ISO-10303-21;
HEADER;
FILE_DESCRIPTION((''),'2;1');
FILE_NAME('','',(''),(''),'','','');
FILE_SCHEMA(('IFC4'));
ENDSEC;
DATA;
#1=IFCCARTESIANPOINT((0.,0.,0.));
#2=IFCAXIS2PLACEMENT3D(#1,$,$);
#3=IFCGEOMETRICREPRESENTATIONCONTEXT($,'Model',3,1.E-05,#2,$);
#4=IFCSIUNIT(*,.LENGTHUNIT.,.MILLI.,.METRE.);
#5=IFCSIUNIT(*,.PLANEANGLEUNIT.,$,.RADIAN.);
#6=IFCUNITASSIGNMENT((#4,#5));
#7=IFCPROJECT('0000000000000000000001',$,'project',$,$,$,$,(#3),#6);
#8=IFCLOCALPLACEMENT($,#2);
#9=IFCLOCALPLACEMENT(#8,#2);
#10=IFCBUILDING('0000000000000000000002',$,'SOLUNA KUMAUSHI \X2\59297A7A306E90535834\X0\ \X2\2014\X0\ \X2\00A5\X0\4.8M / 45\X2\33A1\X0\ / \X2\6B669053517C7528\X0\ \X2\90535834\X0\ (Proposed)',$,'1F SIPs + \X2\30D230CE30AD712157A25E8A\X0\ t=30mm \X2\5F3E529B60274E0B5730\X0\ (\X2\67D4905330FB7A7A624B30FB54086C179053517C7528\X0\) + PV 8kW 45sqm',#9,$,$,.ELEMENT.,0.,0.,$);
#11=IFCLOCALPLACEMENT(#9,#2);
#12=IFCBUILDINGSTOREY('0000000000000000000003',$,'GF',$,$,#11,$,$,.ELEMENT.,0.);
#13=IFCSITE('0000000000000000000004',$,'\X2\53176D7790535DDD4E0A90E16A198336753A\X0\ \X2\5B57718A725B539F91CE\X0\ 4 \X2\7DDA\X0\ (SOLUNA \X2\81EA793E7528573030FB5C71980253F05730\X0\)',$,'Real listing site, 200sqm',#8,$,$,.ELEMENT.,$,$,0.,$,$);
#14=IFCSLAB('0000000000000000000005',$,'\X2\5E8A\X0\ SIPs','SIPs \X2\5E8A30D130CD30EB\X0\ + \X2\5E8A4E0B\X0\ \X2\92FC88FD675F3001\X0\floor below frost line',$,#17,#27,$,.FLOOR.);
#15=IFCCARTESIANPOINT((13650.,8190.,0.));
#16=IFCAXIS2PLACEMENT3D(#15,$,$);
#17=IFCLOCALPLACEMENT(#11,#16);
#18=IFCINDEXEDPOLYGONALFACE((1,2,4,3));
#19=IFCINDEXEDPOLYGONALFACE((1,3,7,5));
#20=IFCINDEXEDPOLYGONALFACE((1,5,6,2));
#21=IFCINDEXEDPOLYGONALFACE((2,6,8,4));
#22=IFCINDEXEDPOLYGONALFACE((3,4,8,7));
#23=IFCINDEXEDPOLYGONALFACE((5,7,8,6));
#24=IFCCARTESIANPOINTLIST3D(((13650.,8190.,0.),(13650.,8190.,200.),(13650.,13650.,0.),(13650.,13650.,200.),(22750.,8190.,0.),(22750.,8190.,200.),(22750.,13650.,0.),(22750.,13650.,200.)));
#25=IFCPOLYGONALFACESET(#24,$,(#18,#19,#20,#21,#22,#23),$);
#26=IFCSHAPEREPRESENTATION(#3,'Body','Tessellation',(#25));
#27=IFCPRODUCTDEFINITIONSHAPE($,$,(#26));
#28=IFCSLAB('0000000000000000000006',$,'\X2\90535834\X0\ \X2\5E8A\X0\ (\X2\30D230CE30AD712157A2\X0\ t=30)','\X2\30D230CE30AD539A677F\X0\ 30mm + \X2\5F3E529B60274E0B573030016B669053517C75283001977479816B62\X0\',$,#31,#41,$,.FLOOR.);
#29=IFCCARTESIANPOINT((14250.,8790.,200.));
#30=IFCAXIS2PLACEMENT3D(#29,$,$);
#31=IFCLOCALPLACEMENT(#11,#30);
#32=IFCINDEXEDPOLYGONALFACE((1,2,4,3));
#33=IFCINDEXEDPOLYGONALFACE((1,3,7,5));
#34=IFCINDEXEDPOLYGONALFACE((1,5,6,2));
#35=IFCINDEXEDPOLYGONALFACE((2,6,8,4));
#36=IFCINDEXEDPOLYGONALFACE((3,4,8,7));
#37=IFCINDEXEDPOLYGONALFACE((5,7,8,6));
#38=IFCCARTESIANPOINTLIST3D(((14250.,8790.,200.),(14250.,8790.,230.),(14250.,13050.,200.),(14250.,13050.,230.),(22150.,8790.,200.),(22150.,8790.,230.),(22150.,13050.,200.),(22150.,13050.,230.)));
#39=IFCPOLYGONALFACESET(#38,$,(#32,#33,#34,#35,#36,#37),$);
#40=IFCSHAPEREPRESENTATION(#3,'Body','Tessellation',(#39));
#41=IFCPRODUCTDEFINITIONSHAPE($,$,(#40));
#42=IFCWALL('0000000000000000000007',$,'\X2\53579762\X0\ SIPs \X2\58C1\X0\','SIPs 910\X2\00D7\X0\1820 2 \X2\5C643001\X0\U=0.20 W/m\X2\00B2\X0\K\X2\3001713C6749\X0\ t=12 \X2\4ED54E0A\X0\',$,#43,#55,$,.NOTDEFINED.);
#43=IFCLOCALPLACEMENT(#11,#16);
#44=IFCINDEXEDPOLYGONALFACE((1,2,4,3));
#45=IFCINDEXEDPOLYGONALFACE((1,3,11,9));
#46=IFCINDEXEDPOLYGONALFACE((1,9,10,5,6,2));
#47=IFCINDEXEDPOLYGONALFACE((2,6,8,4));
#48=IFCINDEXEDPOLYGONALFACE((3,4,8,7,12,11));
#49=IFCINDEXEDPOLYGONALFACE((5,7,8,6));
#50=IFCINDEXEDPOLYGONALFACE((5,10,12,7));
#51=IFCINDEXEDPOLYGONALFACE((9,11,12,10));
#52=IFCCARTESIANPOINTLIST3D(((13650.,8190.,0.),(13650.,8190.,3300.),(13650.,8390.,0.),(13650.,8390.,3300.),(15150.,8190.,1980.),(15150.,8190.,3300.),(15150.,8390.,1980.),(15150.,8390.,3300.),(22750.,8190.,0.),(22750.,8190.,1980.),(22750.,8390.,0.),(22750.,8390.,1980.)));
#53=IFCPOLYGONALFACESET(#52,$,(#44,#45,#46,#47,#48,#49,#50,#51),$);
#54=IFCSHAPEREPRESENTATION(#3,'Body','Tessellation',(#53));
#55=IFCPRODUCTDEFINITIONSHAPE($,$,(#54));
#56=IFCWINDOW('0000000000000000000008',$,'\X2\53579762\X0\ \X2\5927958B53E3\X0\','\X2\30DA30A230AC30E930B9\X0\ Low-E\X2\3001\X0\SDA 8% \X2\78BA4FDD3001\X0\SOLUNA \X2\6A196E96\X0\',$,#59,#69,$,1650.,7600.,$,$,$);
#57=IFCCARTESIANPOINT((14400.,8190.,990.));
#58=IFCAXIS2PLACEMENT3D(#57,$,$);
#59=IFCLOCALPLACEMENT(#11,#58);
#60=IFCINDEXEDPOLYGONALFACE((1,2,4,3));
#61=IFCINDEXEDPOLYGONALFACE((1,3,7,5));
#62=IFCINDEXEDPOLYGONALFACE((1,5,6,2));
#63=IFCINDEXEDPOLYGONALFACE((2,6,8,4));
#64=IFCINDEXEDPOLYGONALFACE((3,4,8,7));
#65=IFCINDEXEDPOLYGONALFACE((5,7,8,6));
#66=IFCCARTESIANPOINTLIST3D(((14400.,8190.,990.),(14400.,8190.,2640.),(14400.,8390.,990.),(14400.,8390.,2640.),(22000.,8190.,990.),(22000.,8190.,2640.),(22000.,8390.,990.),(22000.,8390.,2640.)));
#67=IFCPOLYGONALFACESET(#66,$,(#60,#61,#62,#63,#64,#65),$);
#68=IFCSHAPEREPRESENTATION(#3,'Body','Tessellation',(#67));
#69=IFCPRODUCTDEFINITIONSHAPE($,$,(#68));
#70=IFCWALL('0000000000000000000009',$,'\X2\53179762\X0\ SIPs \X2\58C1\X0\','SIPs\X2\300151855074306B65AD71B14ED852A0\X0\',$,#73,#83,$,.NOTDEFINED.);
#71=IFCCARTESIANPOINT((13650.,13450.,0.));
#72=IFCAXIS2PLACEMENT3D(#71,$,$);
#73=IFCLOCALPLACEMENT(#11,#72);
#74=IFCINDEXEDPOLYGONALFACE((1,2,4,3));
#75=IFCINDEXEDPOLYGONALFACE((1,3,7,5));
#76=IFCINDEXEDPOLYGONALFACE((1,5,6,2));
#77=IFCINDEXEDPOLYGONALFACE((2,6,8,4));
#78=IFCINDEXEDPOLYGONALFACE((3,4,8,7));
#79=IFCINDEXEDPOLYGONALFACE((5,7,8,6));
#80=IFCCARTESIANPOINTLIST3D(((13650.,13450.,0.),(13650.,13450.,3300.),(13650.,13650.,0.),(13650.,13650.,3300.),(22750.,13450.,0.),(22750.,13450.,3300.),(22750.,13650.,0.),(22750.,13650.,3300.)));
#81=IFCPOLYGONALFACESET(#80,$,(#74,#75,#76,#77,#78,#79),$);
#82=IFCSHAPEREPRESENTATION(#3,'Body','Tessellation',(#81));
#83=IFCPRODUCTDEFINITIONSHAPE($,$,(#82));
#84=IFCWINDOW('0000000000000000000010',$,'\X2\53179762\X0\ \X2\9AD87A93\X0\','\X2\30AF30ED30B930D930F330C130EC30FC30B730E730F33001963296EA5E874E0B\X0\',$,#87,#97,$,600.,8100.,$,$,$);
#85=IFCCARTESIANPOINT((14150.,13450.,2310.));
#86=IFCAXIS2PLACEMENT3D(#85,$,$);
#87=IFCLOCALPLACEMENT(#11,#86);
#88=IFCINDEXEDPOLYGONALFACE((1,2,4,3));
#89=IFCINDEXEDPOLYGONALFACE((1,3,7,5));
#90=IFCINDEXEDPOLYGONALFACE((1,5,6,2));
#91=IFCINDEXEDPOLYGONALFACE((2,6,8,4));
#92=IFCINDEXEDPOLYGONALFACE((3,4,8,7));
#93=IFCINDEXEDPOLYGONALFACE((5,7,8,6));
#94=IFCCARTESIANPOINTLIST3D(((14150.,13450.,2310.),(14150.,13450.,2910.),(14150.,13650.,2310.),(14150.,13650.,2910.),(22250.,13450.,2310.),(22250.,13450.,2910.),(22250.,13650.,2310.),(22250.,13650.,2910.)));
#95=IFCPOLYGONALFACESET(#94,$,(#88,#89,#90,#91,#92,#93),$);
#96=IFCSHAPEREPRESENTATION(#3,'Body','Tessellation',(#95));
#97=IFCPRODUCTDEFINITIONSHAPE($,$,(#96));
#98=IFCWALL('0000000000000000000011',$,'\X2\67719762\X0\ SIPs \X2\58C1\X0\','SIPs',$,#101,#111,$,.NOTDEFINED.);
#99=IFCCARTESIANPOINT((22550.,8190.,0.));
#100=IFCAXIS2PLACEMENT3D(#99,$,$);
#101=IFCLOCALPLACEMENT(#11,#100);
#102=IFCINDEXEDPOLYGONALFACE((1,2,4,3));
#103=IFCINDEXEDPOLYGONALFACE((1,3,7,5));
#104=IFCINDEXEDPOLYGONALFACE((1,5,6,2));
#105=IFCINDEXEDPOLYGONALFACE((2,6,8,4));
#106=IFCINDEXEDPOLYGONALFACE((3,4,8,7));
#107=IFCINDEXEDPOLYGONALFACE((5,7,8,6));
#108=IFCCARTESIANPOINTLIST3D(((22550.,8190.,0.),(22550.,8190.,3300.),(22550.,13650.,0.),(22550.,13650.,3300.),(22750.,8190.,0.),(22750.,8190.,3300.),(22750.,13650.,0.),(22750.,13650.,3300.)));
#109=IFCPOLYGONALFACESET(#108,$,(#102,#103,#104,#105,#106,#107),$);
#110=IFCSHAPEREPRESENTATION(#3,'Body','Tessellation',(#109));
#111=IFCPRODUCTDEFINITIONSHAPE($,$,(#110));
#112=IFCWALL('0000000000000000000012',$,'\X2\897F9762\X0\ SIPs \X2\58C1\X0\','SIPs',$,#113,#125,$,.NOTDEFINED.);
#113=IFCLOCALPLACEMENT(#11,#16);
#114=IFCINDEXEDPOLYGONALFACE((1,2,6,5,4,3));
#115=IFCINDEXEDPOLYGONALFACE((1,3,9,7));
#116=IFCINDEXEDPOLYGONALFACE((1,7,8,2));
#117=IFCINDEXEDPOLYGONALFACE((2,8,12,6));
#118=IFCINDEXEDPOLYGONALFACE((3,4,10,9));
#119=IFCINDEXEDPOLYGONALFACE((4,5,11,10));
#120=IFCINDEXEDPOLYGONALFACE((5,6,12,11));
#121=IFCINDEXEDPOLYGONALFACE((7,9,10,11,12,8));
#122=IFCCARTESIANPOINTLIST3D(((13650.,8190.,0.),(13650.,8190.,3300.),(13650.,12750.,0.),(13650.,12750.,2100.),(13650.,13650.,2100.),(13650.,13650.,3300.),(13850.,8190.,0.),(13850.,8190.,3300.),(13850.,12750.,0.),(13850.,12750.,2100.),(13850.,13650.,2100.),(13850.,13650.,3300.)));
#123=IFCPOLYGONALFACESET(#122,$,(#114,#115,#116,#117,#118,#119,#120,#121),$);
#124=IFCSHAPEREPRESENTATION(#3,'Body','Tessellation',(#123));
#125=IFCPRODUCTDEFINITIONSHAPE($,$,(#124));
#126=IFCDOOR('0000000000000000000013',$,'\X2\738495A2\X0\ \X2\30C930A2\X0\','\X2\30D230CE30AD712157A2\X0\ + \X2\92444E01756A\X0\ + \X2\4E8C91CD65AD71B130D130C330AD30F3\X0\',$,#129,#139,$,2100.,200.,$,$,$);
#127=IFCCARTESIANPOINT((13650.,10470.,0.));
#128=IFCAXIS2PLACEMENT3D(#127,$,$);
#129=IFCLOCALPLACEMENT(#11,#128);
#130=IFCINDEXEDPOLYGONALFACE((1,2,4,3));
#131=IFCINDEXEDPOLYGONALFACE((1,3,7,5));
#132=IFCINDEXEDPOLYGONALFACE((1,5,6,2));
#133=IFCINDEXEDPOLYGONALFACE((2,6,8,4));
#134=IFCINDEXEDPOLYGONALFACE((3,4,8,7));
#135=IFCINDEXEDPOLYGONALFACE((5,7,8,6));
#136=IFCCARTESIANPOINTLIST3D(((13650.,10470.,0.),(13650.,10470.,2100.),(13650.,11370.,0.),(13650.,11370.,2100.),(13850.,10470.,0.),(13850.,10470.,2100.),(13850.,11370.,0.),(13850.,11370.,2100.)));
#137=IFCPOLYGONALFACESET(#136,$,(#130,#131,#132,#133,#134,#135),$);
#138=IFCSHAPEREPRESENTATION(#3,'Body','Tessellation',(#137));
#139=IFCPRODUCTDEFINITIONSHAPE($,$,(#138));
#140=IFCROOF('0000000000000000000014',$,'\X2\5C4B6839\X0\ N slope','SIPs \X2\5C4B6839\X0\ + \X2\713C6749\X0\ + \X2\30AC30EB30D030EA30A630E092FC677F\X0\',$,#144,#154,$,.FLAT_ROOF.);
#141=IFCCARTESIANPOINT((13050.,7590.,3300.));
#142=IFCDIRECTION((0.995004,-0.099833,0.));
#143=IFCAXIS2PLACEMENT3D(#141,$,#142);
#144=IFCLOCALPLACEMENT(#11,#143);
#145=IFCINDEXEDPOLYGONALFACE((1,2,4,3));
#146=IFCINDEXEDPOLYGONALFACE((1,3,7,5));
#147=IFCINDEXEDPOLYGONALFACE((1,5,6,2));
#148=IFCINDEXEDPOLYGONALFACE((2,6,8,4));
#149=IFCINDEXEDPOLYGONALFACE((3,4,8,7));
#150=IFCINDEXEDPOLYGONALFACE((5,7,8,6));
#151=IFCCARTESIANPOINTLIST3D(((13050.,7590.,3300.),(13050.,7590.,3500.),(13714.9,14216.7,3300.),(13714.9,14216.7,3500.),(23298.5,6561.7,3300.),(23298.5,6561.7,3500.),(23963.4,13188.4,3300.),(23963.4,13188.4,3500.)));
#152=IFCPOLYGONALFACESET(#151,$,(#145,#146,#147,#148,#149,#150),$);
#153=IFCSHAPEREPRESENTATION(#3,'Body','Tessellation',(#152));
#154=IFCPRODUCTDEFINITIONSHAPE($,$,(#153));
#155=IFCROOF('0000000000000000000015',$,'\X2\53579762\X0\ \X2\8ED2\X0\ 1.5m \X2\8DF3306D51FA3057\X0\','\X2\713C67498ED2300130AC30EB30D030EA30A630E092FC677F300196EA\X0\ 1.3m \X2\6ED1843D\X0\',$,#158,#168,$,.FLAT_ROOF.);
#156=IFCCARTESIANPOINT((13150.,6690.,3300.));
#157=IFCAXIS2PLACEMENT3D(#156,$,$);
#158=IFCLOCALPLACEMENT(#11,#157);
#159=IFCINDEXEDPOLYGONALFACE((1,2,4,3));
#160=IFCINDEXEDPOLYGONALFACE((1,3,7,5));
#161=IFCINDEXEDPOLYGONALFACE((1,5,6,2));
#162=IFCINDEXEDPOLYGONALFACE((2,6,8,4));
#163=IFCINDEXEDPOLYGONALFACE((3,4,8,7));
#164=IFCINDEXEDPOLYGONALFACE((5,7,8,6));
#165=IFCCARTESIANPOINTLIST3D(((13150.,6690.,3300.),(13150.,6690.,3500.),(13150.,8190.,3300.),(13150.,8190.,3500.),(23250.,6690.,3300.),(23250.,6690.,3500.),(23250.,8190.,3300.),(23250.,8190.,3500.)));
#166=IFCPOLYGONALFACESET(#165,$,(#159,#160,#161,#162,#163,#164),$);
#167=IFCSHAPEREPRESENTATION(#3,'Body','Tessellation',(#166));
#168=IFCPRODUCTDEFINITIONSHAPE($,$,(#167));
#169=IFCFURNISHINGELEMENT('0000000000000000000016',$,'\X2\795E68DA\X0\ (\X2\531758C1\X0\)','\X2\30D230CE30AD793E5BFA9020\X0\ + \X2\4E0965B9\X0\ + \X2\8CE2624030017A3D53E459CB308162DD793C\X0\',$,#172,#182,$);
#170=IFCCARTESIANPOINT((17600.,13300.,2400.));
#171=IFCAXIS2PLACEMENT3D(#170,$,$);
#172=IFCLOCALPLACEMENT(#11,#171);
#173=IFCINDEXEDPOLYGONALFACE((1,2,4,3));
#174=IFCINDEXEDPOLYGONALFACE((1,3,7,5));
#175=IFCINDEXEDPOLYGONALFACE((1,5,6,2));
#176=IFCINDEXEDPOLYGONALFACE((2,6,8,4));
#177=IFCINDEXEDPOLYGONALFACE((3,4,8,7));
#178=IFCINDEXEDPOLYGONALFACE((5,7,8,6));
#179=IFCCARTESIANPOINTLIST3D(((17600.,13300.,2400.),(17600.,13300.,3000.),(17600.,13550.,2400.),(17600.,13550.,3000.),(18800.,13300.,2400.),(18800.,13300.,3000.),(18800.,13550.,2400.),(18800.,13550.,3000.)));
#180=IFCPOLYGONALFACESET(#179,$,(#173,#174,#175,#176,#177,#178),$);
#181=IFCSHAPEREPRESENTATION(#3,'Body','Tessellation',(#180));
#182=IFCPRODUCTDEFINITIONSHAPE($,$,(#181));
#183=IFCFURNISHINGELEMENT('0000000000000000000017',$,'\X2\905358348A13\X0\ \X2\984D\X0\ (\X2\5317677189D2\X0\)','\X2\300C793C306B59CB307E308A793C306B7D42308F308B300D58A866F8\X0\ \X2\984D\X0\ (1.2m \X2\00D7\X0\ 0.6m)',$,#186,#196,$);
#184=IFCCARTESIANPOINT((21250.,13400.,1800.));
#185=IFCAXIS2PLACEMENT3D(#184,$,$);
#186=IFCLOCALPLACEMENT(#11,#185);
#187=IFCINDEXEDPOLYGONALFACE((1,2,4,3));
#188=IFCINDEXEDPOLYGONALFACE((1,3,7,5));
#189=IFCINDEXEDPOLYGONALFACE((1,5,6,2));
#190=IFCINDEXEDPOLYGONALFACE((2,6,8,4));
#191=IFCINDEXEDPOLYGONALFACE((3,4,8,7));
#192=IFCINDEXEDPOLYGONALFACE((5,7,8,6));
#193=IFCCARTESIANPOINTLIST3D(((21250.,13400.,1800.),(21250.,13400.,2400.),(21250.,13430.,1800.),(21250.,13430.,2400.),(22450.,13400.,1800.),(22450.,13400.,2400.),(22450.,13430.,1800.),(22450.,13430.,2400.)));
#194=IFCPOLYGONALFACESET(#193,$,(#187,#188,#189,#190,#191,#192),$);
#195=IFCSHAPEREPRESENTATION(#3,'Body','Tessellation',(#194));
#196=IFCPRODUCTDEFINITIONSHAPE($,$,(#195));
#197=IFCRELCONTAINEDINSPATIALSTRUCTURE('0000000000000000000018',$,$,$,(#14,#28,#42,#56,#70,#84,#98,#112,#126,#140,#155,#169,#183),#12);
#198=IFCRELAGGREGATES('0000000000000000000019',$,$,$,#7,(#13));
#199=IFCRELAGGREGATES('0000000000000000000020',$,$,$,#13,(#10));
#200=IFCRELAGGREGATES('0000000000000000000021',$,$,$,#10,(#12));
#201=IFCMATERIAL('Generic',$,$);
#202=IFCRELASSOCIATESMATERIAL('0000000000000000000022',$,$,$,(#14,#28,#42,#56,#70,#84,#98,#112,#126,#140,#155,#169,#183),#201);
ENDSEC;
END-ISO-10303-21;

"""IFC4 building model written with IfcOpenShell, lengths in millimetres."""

from ifc_helpers import new_model, si_unit, frame, frame_2d, origin, place, context, project, spatial, rectangle, extrude, material, element, fill, save


model = new_model("IFC4")

# Units and contexts
model_context = context("Model", 3, precision=1e-05, world=origin())
ifc_project = project(units=[si_unit("LENGTHUNIT", "METRE", prefix="MILLI"), si_unit("PLANEANGLEUNIT", "RADIAN")], contexts=[model_context])

# Site, building, storey
site_placement = place(None, origin())
site = spatial("IfcSite", under=ifc_project, at=site_placement, Name="北海道川上郡標茶町 字熊牛原野 4 線 (SOLUNA 自社用地・山頂台地)", ObjectType="Real listing site, 200sqm", CompositionType="ELEMENT", RefElevation=0.0)
building_placement = place(site_placement, origin())
building = spatial("IfcBuilding", under=site, at=building_placement, Name="SOLUNA KUMAUSHI 天空の道場 — ¥4.8M / 45㎡ / 武道兼用 道場 (Proposed)", ObjectType="1F SIPs + ヒノキ無垢床 t=30mm 弾力性下地 (柔道・空手・合気道兼用) + PV 8kW 45sqm", CompositionType="ELEMENT", ElevationOfRefHeight=0.0, ElevationOfTerrain=0.0)
storey_placement = place(building_placement, origin())
storey = spatial("IfcBuildingStorey", under=building, at=storey_placement, Name="GF", CompositionType="ELEMENT", Elevation=0.0)

# Slabs
ifc_material = material(Name="Generic")
slab_1_placement = place(storey_placement, frame((13650.0, 8190.0, 0.0)))
element("IfcSlab", 1, at=slab_1_placement, inside=storey, material=ifc_material, Name="床 SIPs", Description="SIPs 床パネル + 床下 鋼製束、floor below frost line", PredefinedType="FLOOR", context=model_context, shape_type="SweptSolid", body=[
    extrude(rectangle(XDim=9100.0, YDim=5460.0, at=frame_2d((4550.0, 2730.0))), frame((13650.0, 8190.0, 0.0)), (0.0, 0.0, 1.0), 200.0),
])
slab_2_placement = place(storey_placement, frame((14250.0, 8790.0, 200.0)))
element("IfcSlab", 2, at=slab_2_placement, inside=storey, material=ifc_material, Name="道場 床 (ヒノキ無垢 t=30)", Description="ヒノキ厚板 30mm + 弾力性下地、武道兼用、靴禁止", PredefinedType="FLOOR", context=model_context, shape_type="SweptSolid", body=[
    extrude(rectangle(XDim=7900.0, YDim=4260.0, at=frame_2d((3950.0, 2130.0))), frame((14250.0, 8790.0, 200.0)), (0.0, 0.0, 1.0), 30.0),
])

# Walls, openings, windows
wall_1_placement = place(storey_placement, frame((13650.0, 8190.0, 0.0)))
wall_1 = element("IfcWall", 3, at=wall_1_placement, inside=storey, material=ifc_material, Name="南面 SIPs 壁", Description="SIPs 910×1820 2 層、U=0.20 W/m²K、焼杉 t=12 仕上", PredefinedType="NOTDEFINED", context=model_context, shape_type="SweptSolid", body=[
    extrude(rectangle(XDim=9100.0, YDim=200.0, at=frame_2d((4550.0, 100.0))), frame((13650.0, 8190.0, 0.0)), (0.0, 0.0, 1.0), 3300.0),
])
opening_1_placement = place(storey_placement, frame((14400.0, 8190.0, 990.0)))
opening_1 = element("IfcOpeningElement", 4, at=opening_1_placement, cuts=wall_1, PredefinedType="NOTDEFINED", context=model_context, shape_type="SweptSolid", body=[
    extrude(rectangle(XDim=7600.0, YDim=200.0, at=frame_2d((3800.0, 100.0))), frame((14400.0, 8190.0, 990.0)), (0.0, 0.0, 1.0), 1650.0),
])
window_1_placement = place(storey_placement, frame((14400.0, 8190.0, 990.0)))
window_1 = element("IfcWindow", 5, at=window_1_placement, inside=storey, material=ifc_material, Name="南面 大開口", Description="ペアガラス Low-E、SDA 8% 確保、SOLUNA 標準", OverallHeight=1650.0, OverallWidth=7600.0, context=model_context, shape_type="SweptSolid", body=[
    extrude(rectangle(XDim=7600.0, YDim=200.0, at=frame_2d((3800.0, 100.0))), frame((14400.0, 8190.0, 990.0)), (0.0, 0.0, 1.0), 1650.0),
])
fill(opening_1, window_1)
wall_2_placement = place(storey_placement, frame((13650.0, 13450.0, 0.0)))
wall_2 = element("IfcWall", 6, at=wall_2_placement, inside=storey, material=ifc_material, Name="北面 SIPs 壁", Description="SIPs、内側に断熱付加", PredefinedType="NOTDEFINED", context=model_context, shape_type="SweptSolid", body=[
    extrude(rectangle(XDim=9100.0, YDim=200.0, at=frame_2d((4550.0, 100.0))), frame((13650.0, 13450.0, 0.0)), (0.0, 0.0, 1.0), 3300.0),
])
opening_2_placement = place(storey_placement, frame((14150.0, 13450.0, 2310.0)))
opening_2 = element("IfcOpeningElement", 7, at=opening_2_placement, cuts=wall_2, PredefinedType="NOTDEFINED", context=model_context, shape_type="SweptSolid", body=[
    extrude(rectangle(XDim=8100.0, YDim=200.0, at=frame_2d((4050.0, 100.0))), frame((14150.0, 13450.0, 2310.0)), (0.0, 0.0, 1.0), 600.0),
])
window_2_placement = place(storey_placement, frame((14150.0, 13450.0, 2310.0)))
window_2 = element("IfcWindow", 8, at=window_2_placement, inside=storey, material=ifc_material, Name="北面 高窓", Description="クロスベンチレーション、防雪庇下", OverallHeight=600.0, OverallWidth=8100.0, context=model_context, shape_type="SweptSolid", body=[
    extrude(rectangle(XDim=8100.0, YDim=200.0, at=frame_2d((4050.0, 100.0))), frame((14150.0, 13450.0, 2310.0)), (0.0, 0.0, 1.0), 600.0),
])
fill(opening_2, window_2)

# Wall
wall_3_placement = place(storey_placement, frame((22550.0, 8190.0, 0.0)))
element("IfcWall", 9, at=wall_3_placement, inside=storey, material=ifc_material, Name="東面 SIPs 壁", Description="SIPs", PredefinedType="NOTDEFINED", context=model_context, shape_type="SweptSolid", body=[
    extrude(rectangle(XDim=200.0, YDim=5460.0, at=frame_2d((100.0, 2730.0))), frame((22550.0, 8190.0, 0.0)), (0.0, 0.0, 1.0), 3300.0),
])

# Wall, opening, door
wall_4_placement = place(storey_placement, frame((13650.0, 8190.0, 0.0)))
wall_4 = element("IfcWall", 10, at=wall_4_placement, inside=storey, material=ifc_material, Name="西面 SIPs 壁", Description="SIPs", PredefinedType="NOTDEFINED", context=model_context, shape_type="SweptSolid", body=[
    extrude(rectangle(XDim=200.0, YDim=5460.0, at=frame_2d((100.0, 2730.0))), frame((13650.0, 8190.0, 0.0)), (0.0, 0.0, 1.0), 3300.0),
])
opening_3_placement = place(storey_placement, frame((13650.0, 10470.0, 0.0)))
opening_3 = element("IfcOpeningElement", 11, at=opening_3_placement, cuts=wall_4, PredefinedType="NOTDEFINED", context=model_context, shape_type="SweptSolid", body=[
    extrude(rectangle(XDim=200.0, YDim=900.0, at=frame_2d((100.0, 450.0))), frame((13650.0, 10470.0, 0.0)), (0.0, 0.0, 1.0), 2100.0),
])
door_placement = place(storey_placement, frame((13650.0, 10470.0, 0.0)))
door = element("IfcDoor", 12, at=door_placement, inside=storey, material=ifc_material, Name="玄関 ドア", Description="ヒノキ無垢 + 鉄丁番 + 二重断熱パッキン", OverallHeight=2100.0, OverallWidth=200.0, context=model_context, shape_type="SweptSolid", body=[
    extrude(rectangle(XDim=200.0, YDim=900.0, at=frame_2d((100.0, 450.0))), frame((13650.0, 10470.0, 0.0)), (0.0, 0.0, 1.0), 2100.0),
])
fill(opening_3, door)

# Roofs
roof_1_placement = place(storey_placement, frame((13050.0, 7590.0, 3300.0), x_axis=(0.995004, -0.099833, 0.0)))
element("IfcRoof", 13, at=roof_1_placement, inside=storey, material=ifc_material, Name="屋根 N slope", Description="SIPs 屋根 + 焼杉 + ガルバリウム鋼板", PredefinedType="FLAT_ROOF", context=model_context, shape_type="SweptSolid", body=[
    extrude(rectangle(XDim=10300.0, YDim=6660.0, at=frame_2d((5150.0, 3330.0))), frame((13050.0, 7590.0, 3300.0), x_axis=(0.995004, -0.099833, 0.0)), (0.0, 0.0, 1.0), 200.0),
])
roof_2_placement = place(storey_placement, frame((13150.0, 6690.0, 3300.0)))
element("IfcRoof", 14, at=roof_2_placement, inside=storey, material=ifc_material, Name="南面 軒 1.5m 跳ね出し", Description="焼杉軒、ガルバリウム鋼板、雪 1.3m 滑落", PredefinedType="FLAT_ROOF", context=model_context, shape_type="SweptSolid", body=[
    extrude(rectangle(XDim=10100.0, YDim=1500.0, at=frame_2d((5050.0, 750.0))), frame((13150.0, 6690.0, 3300.0)), (0.0, 0.0, 1.0), 200.0),
])

# Furnishing elements
furnishing_1_placement = place(storey_placement, frame((17600.0, 13300.0, 2400.0)))
element("IfcFurnishingElement", 15, at=furnishing_1_placement, inside=storey, material=ifc_material, Name="神棚 (北壁)", Description="ヒノキ社寺造 + 三方 + 賢所、稽古始め拝礼", context=model_context, shape_type="SweptSolid", body=[
    extrude(rectangle(XDim=1200.0, YDim=250.0, at=frame_2d((600.0, 125.0))), frame((17600.0, 13300.0, 2400.0)), (0.0, 0.0, 1.0), 600.0),
])
furnishing_2_placement = place(storey_placement, frame((21250.0, 13400.0, 1800.0)))
element("IfcFurnishingElement", 16, at=furnishing_2_placement, inside=storey, material=ifc_material, Name="道場訓 額 (北東角)", Description="「礼に始まり礼に終わる」墨書 額 (1.2m × 0.6m)", context=model_context, shape_type="SweptSolid", body=[
    extrude(rectangle(XDim=1200.0, YDim=30.0, at=frame_2d((600.0, 15.0))), frame((21250.0, 13400.0, 1800.0)), (0.0, 0.0, 1.0), 600.0),
])

save(model, "model.ifc")
